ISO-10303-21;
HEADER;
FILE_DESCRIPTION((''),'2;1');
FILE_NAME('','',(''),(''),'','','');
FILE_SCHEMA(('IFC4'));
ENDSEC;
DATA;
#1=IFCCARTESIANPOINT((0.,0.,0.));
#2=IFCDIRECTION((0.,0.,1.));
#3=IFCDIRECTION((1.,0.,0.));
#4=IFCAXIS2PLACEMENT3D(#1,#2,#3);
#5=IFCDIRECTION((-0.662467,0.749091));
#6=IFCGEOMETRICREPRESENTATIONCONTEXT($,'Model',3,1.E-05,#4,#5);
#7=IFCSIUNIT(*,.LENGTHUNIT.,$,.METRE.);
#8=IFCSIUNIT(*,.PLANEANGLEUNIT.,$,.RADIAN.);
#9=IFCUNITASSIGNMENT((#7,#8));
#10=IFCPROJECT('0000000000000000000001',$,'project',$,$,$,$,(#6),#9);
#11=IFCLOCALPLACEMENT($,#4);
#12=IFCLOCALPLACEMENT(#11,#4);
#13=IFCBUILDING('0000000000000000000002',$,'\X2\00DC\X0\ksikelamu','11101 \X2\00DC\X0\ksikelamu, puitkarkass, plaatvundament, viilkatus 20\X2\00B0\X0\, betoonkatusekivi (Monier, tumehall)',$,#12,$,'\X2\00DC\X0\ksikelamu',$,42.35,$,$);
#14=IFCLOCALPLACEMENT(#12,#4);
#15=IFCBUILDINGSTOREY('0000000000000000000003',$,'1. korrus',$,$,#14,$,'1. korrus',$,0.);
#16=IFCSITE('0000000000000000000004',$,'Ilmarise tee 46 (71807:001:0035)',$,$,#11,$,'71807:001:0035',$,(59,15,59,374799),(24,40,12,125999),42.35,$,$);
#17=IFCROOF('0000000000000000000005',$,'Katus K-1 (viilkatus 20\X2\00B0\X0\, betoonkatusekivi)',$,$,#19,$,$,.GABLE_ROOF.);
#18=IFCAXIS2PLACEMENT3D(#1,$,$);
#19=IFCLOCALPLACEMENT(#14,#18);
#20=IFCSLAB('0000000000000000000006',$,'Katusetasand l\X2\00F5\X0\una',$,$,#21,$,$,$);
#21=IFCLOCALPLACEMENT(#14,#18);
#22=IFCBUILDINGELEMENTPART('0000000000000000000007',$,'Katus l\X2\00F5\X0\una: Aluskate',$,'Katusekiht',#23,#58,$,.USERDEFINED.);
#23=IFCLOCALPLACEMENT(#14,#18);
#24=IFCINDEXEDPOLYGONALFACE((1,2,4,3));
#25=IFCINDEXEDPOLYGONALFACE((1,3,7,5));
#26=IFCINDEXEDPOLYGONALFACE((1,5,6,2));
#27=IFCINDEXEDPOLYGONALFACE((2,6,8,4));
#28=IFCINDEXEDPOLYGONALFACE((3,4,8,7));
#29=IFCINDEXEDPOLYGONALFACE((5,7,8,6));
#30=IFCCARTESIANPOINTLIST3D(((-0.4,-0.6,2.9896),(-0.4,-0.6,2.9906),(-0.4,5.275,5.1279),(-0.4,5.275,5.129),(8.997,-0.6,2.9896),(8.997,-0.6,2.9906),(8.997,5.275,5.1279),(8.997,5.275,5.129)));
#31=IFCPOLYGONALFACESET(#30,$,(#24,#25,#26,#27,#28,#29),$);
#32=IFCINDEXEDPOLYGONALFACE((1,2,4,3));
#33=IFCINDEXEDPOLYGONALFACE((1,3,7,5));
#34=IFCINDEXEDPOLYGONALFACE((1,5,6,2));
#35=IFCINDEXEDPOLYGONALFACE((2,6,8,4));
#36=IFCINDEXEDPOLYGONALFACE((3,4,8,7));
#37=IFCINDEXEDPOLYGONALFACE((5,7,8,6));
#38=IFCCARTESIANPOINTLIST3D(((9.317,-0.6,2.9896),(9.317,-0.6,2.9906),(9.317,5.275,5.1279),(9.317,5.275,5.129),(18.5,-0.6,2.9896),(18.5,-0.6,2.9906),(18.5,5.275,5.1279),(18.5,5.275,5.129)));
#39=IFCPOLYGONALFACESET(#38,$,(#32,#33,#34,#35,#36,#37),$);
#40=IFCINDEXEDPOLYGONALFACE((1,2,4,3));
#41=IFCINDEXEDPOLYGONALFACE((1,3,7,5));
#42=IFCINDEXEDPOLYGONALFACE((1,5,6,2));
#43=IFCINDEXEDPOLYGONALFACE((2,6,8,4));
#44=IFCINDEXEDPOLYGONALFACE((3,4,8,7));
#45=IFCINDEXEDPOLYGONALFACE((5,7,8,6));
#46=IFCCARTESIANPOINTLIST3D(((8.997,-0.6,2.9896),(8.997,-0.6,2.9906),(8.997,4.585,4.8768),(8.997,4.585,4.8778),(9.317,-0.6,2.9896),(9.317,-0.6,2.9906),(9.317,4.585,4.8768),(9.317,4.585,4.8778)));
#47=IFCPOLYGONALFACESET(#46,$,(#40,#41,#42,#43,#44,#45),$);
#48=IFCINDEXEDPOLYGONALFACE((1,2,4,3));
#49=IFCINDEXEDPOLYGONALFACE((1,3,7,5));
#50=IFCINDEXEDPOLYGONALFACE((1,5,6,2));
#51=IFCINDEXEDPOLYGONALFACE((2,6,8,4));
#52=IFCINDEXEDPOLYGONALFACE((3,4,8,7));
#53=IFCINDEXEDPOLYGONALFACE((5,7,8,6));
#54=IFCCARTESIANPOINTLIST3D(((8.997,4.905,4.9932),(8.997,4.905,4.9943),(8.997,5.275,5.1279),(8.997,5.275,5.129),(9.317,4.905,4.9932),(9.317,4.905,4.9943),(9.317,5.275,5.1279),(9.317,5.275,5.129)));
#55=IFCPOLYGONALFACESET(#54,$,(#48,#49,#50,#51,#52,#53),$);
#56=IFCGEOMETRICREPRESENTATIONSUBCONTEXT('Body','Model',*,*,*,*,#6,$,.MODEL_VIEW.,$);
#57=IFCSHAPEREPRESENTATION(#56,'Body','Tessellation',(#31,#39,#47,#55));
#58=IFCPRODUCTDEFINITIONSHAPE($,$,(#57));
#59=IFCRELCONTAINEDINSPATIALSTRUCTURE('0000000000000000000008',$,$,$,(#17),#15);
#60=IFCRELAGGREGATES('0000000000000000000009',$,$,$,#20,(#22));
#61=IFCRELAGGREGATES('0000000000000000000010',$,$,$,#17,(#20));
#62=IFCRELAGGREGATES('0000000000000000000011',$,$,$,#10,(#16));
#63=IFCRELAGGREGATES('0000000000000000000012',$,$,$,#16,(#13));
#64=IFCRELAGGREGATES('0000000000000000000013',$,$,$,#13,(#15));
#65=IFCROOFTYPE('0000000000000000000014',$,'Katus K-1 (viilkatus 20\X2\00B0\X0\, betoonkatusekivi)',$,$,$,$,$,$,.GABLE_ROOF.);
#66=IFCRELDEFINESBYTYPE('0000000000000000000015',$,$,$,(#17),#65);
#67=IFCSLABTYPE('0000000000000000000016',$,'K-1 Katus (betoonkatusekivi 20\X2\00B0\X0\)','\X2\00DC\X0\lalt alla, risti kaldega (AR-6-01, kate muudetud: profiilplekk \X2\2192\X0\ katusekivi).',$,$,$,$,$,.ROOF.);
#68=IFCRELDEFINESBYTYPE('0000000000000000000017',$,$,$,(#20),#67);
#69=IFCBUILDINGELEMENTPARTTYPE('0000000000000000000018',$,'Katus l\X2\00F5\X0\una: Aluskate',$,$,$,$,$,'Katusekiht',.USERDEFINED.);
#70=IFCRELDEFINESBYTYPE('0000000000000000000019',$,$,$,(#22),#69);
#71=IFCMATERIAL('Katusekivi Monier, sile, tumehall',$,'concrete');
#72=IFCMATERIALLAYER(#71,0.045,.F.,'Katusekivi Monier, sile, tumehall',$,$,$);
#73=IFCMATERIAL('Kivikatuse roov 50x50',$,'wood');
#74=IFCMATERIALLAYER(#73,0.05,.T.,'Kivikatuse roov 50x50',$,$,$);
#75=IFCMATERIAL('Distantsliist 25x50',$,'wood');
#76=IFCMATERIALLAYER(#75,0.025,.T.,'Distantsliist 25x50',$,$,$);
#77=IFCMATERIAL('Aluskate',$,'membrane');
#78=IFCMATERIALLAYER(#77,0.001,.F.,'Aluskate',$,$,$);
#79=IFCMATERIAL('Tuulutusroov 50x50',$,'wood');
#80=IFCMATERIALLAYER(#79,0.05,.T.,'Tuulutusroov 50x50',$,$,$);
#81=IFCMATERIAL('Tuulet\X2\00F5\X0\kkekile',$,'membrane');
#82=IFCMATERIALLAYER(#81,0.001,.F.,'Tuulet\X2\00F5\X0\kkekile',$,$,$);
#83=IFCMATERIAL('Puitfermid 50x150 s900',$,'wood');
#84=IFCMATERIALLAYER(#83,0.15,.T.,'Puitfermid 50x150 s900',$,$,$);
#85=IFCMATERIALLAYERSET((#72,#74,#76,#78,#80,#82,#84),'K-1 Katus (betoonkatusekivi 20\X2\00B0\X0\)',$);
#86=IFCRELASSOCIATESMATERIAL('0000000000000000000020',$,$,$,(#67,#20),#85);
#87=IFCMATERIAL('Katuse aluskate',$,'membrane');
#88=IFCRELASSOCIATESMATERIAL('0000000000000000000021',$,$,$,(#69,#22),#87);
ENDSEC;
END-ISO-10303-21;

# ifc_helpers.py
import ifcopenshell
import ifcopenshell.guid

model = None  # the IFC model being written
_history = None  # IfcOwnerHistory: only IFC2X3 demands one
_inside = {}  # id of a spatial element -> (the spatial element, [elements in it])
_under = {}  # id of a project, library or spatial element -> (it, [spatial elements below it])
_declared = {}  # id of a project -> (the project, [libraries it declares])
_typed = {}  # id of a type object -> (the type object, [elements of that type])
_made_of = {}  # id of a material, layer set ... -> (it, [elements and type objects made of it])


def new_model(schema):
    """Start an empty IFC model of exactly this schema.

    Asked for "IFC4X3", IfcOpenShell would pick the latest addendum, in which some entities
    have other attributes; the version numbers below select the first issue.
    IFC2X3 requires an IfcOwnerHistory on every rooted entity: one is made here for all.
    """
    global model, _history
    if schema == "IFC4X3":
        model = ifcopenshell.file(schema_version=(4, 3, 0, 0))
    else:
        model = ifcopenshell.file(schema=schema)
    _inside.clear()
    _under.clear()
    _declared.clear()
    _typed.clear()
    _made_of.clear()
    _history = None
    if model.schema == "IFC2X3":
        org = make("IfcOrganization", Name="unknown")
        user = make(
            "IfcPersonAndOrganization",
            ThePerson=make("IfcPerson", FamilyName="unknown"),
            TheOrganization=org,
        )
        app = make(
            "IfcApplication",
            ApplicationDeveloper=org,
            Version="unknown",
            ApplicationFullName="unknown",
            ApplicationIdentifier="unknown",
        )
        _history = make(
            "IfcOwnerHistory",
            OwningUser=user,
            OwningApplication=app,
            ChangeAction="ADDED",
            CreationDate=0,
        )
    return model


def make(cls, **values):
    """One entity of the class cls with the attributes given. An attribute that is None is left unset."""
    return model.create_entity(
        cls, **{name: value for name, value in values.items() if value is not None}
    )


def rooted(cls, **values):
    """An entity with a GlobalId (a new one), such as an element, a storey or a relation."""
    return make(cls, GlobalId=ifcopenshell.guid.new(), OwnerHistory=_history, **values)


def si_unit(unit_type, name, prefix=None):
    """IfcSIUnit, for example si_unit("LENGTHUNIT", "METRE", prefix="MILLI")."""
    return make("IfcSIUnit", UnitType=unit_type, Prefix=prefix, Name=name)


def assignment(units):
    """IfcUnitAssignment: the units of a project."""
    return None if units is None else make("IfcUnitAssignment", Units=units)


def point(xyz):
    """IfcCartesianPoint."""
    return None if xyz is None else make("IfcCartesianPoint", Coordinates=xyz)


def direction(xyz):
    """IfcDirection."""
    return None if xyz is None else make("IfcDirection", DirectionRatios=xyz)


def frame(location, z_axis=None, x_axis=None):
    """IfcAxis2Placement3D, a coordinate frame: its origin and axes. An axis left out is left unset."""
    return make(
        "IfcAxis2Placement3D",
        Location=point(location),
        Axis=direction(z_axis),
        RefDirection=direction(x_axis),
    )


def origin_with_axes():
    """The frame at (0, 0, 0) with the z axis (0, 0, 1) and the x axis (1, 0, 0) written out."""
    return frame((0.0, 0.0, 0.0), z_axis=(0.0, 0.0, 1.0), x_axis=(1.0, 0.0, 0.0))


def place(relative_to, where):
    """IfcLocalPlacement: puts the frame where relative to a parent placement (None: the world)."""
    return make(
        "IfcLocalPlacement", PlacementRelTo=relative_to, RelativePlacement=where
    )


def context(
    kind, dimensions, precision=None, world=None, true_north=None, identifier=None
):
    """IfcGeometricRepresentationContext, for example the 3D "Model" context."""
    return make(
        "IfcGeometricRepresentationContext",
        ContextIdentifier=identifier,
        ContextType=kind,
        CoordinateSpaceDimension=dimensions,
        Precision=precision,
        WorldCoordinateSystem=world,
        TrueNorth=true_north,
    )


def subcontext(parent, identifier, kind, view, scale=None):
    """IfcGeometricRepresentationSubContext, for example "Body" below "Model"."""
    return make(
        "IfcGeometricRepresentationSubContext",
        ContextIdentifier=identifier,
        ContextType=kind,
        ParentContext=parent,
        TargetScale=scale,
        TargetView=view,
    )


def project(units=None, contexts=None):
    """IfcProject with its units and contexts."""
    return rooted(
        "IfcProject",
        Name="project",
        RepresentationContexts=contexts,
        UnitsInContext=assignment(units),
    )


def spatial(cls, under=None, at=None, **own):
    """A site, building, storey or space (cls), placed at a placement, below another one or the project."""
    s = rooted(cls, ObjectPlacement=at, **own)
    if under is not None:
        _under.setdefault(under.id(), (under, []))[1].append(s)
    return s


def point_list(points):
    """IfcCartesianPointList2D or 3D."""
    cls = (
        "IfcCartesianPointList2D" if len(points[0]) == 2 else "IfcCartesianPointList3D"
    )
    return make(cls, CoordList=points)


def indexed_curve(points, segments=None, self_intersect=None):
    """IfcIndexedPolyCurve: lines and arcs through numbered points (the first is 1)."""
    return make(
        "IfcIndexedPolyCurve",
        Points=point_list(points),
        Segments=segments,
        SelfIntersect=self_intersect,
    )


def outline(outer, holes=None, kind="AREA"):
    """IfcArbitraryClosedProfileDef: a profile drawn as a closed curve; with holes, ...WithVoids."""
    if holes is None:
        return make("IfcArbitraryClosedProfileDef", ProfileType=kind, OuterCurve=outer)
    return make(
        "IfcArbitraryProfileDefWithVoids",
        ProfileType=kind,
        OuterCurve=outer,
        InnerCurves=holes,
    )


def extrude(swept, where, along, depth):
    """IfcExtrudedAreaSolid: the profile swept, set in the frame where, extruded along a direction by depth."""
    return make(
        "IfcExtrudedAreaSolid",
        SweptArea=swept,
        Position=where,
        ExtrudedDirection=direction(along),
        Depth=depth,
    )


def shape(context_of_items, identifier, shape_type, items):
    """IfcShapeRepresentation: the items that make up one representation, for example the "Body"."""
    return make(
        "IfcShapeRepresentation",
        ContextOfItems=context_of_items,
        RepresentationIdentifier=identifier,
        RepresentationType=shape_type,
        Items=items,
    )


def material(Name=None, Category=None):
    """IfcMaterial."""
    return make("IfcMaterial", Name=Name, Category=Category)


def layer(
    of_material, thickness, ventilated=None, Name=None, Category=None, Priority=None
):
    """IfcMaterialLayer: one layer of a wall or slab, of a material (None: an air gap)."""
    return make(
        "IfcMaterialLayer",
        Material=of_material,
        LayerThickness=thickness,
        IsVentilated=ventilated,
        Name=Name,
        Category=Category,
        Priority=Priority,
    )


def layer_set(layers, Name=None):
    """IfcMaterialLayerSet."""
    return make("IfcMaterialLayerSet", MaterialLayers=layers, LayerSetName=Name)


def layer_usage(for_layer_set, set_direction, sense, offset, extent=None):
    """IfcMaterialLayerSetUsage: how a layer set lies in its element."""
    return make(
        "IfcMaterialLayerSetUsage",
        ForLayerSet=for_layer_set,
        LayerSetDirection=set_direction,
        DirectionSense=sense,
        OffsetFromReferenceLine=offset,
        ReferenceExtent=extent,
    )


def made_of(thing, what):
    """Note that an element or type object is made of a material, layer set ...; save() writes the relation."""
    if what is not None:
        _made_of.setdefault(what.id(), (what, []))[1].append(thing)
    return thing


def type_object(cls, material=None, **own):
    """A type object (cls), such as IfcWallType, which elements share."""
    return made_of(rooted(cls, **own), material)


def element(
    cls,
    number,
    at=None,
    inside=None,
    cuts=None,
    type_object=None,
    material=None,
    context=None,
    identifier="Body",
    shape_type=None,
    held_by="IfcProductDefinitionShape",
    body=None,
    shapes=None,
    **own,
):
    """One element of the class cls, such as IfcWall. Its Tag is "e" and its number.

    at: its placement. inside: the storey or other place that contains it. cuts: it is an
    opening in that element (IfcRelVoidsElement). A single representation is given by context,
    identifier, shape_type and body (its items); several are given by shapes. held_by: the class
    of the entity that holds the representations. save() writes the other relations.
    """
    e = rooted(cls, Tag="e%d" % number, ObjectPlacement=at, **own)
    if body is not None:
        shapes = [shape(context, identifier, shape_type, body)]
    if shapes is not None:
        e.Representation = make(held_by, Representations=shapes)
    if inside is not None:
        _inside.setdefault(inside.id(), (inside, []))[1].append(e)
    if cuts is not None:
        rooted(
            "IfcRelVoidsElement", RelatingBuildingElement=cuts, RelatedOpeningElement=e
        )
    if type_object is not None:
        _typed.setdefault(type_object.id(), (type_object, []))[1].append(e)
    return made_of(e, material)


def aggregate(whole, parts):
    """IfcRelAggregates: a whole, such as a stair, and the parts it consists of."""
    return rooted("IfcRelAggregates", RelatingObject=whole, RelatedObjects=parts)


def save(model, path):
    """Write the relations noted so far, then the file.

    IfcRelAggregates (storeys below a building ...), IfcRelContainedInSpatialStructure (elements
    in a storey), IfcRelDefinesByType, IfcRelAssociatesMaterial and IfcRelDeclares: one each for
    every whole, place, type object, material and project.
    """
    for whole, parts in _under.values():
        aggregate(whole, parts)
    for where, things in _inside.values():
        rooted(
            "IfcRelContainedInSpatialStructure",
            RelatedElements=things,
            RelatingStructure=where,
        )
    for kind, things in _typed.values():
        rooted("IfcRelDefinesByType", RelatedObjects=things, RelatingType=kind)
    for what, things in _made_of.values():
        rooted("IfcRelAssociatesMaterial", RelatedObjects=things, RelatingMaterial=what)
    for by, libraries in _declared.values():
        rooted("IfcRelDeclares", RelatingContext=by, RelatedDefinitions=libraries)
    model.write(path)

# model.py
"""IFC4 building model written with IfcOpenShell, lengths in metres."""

from ifc_helpers import new_model, si_unit, direction, frame, origin_with_axes, place, context, subcontext, project, spatial, indexed_curve, outline, extrude, material, layer, layer_set, layer_usage, type_object, element, aggregate, save


model = new_model("IFC4")

# Units and contexts
model_context = context("Model", 3, precision=1e-05, world=origin_with_axes(), true_north=direction((-0.662467, 0.749091)))
body_context = subcontext(model_context, "Body", "Model", "MODEL_VIEW")
ifc_project = project(units=[si_unit("LENGTHUNIT", "METRE"), si_unit("PLANEANGLEUNIT", "RADIAN")], contexts=[model_context])

# Site, building, storey
site_placement = place(None, origin_with_axes())
site = spatial("IfcSite", under=ifc_project, at=site_placement, Name="Ilmarise tee 46 (71807:001:0035)", LongName="71807:001:0035", RefLatitude=(59, 15, 59, 374799), RefLongitude=(24, 40, 12, 125999), RefElevation=42.35)
building_placement = place(site_placement, origin_with_axes())
building = spatial("IfcBuilding", under=site, at=building_placement, Name="Üksikelamu", Description="11101 Üksikelamu, puitkarkass, plaatvundament, viilkatus 20°, betoonkatusekivi (Monier, tumehall)", LongName="Üksikelamu", ElevationOfRefHeight=42.35)
storey_placement = place(building_placement, origin_with_axes())
storey = spatial("IfcBuildingStorey", under=building, at=storey_placement, Name="1. korrus", LongName="1. korrus", Elevation=0.0)

# Roof
roof_type = type_object("IfcRoofType", Name="Katus K-1 (viilkatus 20°, betoonkatusekivi)", PredefinedType="GABLE_ROOF")
roof_placement = place(storey_placement, origin_with_axes())
roof = element("IfcRoof", 1, at=roof_placement, inside=storey, type_object=roof_type, Name="Katus K-1 (viilkatus 20°, betoonkatusekivi)", PredefinedType="GABLE_ROOF")

# Slab, building element part
ifc_material_1 = material(Name="Katusekivi Monier, sile, tumehall", Category="concrete")
ifc_layer_1 = layer(ifc_material_1, 0.045, ventilated=False, Name="Katusekivi Monier, sile, tumehall")
ifc_material_2 = material(Name="Kivikatuse roov 50x50", Category="wood")
ifc_layer_2 = layer(ifc_material_2, 0.05, ventilated=True, Name="Kivikatuse roov 50x50")
ifc_material_3 = material(Name="Distantsliist 25x50", Category="wood")
ifc_layer_3 = layer(ifc_material_3, 0.025, ventilated=True, Name="Distantsliist 25x50")
ifc_material_4 = material(Name="Aluskate", Category="membrane")
ifc_layer_4 = layer(ifc_material_4, 0.001, ventilated=False, Name="Aluskate")
ifc_material_5 = material(Name="Tuulutusroov 50x50", Category="wood")
ifc_layer_5 = layer(ifc_material_5, 0.05, ventilated=True, Name="Tuulutusroov 50x50")
ifc_material_6 = material(Name="Tuuletõkkekile", Category="membrane")
ifc_layer_6 = layer(ifc_material_6, 0.001, ventilated=False, Name="Tuuletõkkekile")
ifc_material_7 = material(Name="Puitfermid 50x150 s900", Category="wood")
ifc_layer_7 = layer(ifc_material_7, 0.15, ventilated=True, Name="Puitfermid 50x150 s900")
ifc_layer_set = layer_set([ifc_layer_1, ifc_layer_2, ifc_layer_3, ifc_layer_4, ifc_layer_5, ifc_layer_6, ifc_layer_7], Name="K-1 Katus (betoonkatusekivi 20°)")
ifc_layer_usage_1 = layer_usage(ifc_layer_set, "AXIS3", "POSITIVE", 0.0)
slab_type = type_object("IfcSlabType", Name="K-1 Katus (betoonkatusekivi 20°)", Description="Ülalt alla, risti kaldega (AR-6-01, kate muudetud: profiilplekk → katusekivi).", PredefinedType="ROOF", material=ifc_layer_set)
slab_1_placement = place(roof_placement, origin_with_axes())
slab_1 = element("IfcSlab", 2, at=slab_1_placement, type_object=slab_type, material=ifc_layer_usage_1, Name="Katusetasand lõuna")
ifc_material_8 = material(Name="Katuse aluskate", Category="membrane")
building_element_part_type_1 = type_object("IfcBuildingElementPartType", Name="Katus lõuna: Aluskate", ElementType="Katusekiht", PredefinedType="USERDEFINED", material=ifc_material_8)
building_element_part_1_placement = place(slab_1_placement, origin_with_axes())
building_element_part_1 = element("IfcBuildingElementPart", 3, at=building_element_part_1_placement, type_object=building_element_part_type_1, material=ifc_material_8, Name="Katus lõuna: Aluskate", ObjectType="Katusekiht", PredefinedType="USERDEFINED", context=body_context, shape_type="SweptSolid", body=[
    extrude(outline(indexed_curve([(-0.6, 2.9896), (5.275, 5.1279), (5.275, 5.129), (-0.6, 2.9906), (-0.6, 2.9896)], self_intersect=False)), frame((-0.4, 0.0, 0.0), z_axis=(1.0, 0.0, 0.0), x_axis=(0.0, 1.0, 0.0)), (0.0, 0.0, 1.0), 9.397),
    extrude(outline(indexed_curve([(-0.6, 2.9896), (5.275, 5.1279), (5.275, 5.129), (-0.6, 2.9906), (-0.6, 2.9896)], self_intersect=False)), frame((9.317, 0.0, 0.0), z_axis=(1.0, 0.0, 0.0), x_axis=(0.0, 1.0, 0.0)), (0.0, 0.0, 1.0), 9.183),
    extrude(outline(indexed_curve([(-0.6, 2.9896), (-0.6, 2.9906), (4.585, 4.8778), (4.585, 4.8768), (-0.6, 2.9896)], self_intersect=False)), frame((8.997, 0.0, 0.0), z_axis=(1.0, 0.0, 0.0), x_axis=(0.0, 1.0, 0.0)), (0.0, 0.0, 1.0), 0.32),
    extrude(outline(indexed_curve([(5.275, 5.129), (5.275, 5.1279), (4.905, 4.9932), (4.905, 4.9943), (5.275, 5.129)], self_intersect=False)), frame((8.997, 0.0, 0.0), z_axis=(1.0, 0.0, 0.0), x_axis=(0.0, 1.0, 0.0)), (0.0, 0.0, 1.0), 0.32),
])
aggregate(slab_1, [building_element_part_1])

aggregate(roof, [slab_1])

save(model, "model.ifc")
